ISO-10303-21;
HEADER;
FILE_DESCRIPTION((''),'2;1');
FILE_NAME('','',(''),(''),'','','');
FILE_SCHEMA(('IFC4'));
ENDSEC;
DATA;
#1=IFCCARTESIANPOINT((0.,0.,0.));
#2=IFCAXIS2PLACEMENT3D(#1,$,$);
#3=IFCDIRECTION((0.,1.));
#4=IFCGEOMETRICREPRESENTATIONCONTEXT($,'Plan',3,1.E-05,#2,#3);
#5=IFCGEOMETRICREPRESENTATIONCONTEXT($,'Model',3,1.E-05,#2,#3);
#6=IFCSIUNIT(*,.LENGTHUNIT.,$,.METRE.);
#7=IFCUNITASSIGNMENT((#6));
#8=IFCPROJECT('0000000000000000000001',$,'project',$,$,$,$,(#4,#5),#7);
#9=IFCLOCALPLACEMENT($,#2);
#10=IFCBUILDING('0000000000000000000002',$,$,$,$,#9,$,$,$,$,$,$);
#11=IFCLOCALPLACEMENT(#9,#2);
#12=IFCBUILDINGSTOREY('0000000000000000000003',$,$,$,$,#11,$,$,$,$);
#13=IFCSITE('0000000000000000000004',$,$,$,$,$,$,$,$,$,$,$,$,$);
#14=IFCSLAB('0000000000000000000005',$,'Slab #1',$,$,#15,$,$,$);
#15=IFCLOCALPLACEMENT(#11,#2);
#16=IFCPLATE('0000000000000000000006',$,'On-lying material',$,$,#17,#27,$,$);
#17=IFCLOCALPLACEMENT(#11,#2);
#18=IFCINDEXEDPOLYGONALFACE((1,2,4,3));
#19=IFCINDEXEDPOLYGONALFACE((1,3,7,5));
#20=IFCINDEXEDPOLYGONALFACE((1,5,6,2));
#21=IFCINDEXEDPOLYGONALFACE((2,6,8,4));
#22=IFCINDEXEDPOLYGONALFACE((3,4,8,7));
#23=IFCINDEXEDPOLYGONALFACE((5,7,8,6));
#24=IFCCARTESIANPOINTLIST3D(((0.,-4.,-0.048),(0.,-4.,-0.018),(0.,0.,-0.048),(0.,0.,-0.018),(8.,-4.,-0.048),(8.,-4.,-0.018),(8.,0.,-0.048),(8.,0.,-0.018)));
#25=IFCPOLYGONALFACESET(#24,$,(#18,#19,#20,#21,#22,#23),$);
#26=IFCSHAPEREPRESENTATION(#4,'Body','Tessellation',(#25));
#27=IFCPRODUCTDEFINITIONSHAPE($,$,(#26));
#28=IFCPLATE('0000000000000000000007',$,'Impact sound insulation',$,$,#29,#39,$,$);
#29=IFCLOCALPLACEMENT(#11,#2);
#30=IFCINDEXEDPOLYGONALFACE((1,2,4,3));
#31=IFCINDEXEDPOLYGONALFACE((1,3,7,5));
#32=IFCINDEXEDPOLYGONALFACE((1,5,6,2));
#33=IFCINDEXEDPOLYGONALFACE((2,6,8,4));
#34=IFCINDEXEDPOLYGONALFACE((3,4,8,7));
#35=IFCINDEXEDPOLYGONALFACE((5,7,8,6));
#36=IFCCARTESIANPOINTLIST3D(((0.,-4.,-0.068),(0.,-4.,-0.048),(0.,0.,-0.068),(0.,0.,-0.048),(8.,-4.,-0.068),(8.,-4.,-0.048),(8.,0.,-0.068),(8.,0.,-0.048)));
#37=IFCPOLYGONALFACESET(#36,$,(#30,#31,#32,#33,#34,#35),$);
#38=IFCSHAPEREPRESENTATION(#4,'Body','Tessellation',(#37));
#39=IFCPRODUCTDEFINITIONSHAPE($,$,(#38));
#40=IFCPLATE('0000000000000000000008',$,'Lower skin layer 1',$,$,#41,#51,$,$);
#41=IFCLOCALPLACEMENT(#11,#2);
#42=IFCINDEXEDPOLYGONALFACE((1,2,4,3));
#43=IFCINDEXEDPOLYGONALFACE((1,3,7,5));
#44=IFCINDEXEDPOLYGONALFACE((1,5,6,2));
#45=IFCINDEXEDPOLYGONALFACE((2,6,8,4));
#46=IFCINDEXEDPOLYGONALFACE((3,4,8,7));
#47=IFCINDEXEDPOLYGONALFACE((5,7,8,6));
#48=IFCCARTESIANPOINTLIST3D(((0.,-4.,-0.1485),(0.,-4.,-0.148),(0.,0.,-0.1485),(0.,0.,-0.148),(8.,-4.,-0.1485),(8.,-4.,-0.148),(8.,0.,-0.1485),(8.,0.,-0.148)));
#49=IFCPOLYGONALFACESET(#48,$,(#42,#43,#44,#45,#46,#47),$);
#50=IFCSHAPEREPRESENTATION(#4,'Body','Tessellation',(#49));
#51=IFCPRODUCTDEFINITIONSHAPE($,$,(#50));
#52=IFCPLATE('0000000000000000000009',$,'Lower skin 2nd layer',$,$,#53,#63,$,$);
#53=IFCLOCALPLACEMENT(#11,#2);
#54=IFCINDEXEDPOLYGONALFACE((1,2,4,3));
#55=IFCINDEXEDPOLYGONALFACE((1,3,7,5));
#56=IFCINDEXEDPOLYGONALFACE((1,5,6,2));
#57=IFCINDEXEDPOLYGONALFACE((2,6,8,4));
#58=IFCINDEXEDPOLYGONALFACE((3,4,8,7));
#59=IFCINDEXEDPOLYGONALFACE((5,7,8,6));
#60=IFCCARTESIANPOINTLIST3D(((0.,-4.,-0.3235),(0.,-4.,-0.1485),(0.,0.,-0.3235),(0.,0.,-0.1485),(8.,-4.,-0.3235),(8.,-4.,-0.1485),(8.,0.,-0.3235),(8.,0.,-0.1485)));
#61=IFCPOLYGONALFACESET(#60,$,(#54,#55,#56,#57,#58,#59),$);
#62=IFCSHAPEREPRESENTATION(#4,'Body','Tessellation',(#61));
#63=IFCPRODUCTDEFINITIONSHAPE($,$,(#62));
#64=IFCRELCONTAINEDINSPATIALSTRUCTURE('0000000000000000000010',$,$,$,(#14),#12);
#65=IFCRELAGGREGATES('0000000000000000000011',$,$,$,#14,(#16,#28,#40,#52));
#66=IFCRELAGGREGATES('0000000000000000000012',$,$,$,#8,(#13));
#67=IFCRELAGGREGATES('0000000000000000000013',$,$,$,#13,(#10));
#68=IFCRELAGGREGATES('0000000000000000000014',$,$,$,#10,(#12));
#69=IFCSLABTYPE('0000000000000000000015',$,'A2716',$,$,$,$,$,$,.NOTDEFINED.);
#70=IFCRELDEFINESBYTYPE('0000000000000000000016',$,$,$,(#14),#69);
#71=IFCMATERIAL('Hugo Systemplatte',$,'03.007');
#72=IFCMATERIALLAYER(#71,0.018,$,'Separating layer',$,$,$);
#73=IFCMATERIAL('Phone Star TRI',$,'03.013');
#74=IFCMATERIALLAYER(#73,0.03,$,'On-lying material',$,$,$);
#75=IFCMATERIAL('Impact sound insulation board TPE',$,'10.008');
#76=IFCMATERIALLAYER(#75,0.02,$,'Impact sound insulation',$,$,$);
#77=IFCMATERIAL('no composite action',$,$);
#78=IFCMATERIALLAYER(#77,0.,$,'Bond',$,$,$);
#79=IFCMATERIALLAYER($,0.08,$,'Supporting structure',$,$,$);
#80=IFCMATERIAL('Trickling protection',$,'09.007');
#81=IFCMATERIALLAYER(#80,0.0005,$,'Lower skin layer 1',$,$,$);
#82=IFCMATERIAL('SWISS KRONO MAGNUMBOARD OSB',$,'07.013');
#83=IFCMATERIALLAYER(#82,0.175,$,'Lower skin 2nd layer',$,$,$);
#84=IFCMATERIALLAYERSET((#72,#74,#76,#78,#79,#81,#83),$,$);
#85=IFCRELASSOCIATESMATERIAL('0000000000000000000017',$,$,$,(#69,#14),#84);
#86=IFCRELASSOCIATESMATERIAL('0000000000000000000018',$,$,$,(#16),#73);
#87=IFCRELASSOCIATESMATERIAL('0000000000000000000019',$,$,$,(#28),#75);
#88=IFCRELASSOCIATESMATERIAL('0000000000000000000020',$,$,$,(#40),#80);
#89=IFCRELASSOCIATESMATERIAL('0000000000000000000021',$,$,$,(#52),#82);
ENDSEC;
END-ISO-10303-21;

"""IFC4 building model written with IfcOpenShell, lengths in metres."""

from ifc_helpers import new_model, si_unit, direction, frame, frame_2d, origin, place, context, project, spatial, rectangle, extrude, material, layer, layer_set, type_object, element, aggregate, save


model = new_model("IFC4")

# Units and contexts
plan_context = context("Plan", 3, precision=1e-05, world=origin(), true_north=direction((0.0, 1.0)))
model_context = context("Model", 3, precision=1e-05, world=origin(), true_north=direction((0.0, 1.0)))
ifc_project = project(units=[si_unit("LENGTHUNIT", "METRE")], contexts=[plan_context, model_context])

# Site, building, storey
site = spatial("IfcSite", under=ifc_project)
building_placement = place(None, origin())
building = spatial("IfcBuilding", under=site, at=building_placement)
storey_placement = place(building_placement, origin())
storey = spatial("IfcBuildingStorey", under=building, at=storey_placement)

# Slab, plates
ifc_material_1 = material(Name="Hugo Systemplatte", Category="03.007")
ifc_layer_1 = layer(ifc_material_1, 0.018, Name="Separating layer")
ifc_material_2 = material(Name="Phone Star TRI", Category="03.013")
ifc_layer_2 = layer(ifc_material_2, 0.03, Name="On-lying material")
ifc_material_3 = material(Name="Impact sound insulation board TPE", Category="10.008")
ifc_layer_3 = layer(ifc_material_3, 0.02, Name="Impact sound insulation")
ifc_material_4 = material(Name="no composite action")
ifc_layer_4 = layer(ifc_material_4, 0.0, Name="Bond")
ifc_layer_5 = layer(None, 0.08, Name="Supporting structure")
ifc_material_5 = material(Name="Trickling protection", Category="09.007")
ifc_layer_6 = layer(ifc_material_5, 0.0005, Name="Lower skin layer 1")
ifc_material_6 = material(Name="SWISS KRONO MAGNUMBOARD OSB", Category="07.013")
ifc_layer_7 = layer(ifc_material_6, 0.175, Name="Lower skin 2nd layer")
ifc_layer_set = layer_set([ifc_layer_1, ifc_layer_2, ifc_layer_3, ifc_layer_4, ifc_layer_5, ifc_layer_6, ifc_layer_7])
slab_type = type_object("IfcSlabType", Name="A2716", PredefinedType="NOTDEFINED", material=ifc_layer_set)
slab_placement = place(None, frame((0.0, 0.0, 0.0), z_axis=(0.0, 0.0, -1.0), x_axis=(1.0, 0.0, 0.0)))
slab = element("IfcSlab", 1, at=slab_placement, inside=storey, type_object=slab_type, material=ifc_layer_set, Name="Slab #1")
plate_1_placement = place(slab_placement, origin())
plate_1 = element("IfcPlate", 2, at=plate_1_placement, material=ifc_material_2, Name="On-lying material", context=plan_context, shape_type="SweptSolid", body=[
    extrude(rectangle(XDim=8.0, YDim=4.0, at=frame_2d((4.0, 2.0), x_axis=(1.0, 0.0))), frame((0.0, 0.0, 0.018), z_axis=(0.0, 0.0, 1.0), x_axis=(1.0, 0.0, 0.0)), (0.0, 0.0, 1.0), 0.03),
])
plate_2_placement = place(slab_placement, origin())
plate_2 = element("IfcPlate", 3, at=plate_2_placement, material=ifc_material_3, Name="Impact sound insulation", context=plan_context, shape_type="SweptSolid", body=[
    extrude(rectangle(XDim=8.0, YDim=4.0, at=frame_2d((4.0, 2.0), x_axis=(1.0, 0.0))), frame((0.0, 0.0, 0.048), z_axis=(0.0, 0.0, 1.0), x_axis=(1.0, 0.0, 0.0)), (0.0, 0.0, 1.0), 0.02),
])
plate_3_placement = place(slab_placement, origin())
plate_3 = element("IfcPlate", 4, at=plate_3_placement, material=ifc_material_5, Name="Lower skin layer 1", context=plan_context, shape_type="SweptSolid", body=[
    extrude(rectangle(XDim=8.0, YDim=4.0, at=frame_2d((4.0, 2.0), x_axis=(1.0, 0.0))), frame((0.0, 0.0, 0.148), z_axis=(0.0, 0.0, 1.0), x_axis=(1.0, 0.0, 0.0)), (0.0, 0.0, 1.0), 0.0005),
])
plate_4_placement = place(slab_placement, origin())
plate_4 = element("IfcPlate", 5, at=plate_4_placement, material=ifc_material_6, Name="Lower skin 2nd layer", context=plan_context, shape_type="SweptSolid", body=[
    extrude(rectangle(XDim=8.0, YDim=4.0, at=frame_2d((4.0, 2.0), x_axis=(1.0, 0.0))), frame((0.0, 0.0, 0.1485), z_axis=(0.0, 0.0, 1.0), x_axis=(1.0, 0.0, 0.0)), (0.0, 0.0, 1.0), 0.175),
])
aggregate(slab, [plate_1, plate_2, plate_3, plate_4])

save(model, "model.ifc")
